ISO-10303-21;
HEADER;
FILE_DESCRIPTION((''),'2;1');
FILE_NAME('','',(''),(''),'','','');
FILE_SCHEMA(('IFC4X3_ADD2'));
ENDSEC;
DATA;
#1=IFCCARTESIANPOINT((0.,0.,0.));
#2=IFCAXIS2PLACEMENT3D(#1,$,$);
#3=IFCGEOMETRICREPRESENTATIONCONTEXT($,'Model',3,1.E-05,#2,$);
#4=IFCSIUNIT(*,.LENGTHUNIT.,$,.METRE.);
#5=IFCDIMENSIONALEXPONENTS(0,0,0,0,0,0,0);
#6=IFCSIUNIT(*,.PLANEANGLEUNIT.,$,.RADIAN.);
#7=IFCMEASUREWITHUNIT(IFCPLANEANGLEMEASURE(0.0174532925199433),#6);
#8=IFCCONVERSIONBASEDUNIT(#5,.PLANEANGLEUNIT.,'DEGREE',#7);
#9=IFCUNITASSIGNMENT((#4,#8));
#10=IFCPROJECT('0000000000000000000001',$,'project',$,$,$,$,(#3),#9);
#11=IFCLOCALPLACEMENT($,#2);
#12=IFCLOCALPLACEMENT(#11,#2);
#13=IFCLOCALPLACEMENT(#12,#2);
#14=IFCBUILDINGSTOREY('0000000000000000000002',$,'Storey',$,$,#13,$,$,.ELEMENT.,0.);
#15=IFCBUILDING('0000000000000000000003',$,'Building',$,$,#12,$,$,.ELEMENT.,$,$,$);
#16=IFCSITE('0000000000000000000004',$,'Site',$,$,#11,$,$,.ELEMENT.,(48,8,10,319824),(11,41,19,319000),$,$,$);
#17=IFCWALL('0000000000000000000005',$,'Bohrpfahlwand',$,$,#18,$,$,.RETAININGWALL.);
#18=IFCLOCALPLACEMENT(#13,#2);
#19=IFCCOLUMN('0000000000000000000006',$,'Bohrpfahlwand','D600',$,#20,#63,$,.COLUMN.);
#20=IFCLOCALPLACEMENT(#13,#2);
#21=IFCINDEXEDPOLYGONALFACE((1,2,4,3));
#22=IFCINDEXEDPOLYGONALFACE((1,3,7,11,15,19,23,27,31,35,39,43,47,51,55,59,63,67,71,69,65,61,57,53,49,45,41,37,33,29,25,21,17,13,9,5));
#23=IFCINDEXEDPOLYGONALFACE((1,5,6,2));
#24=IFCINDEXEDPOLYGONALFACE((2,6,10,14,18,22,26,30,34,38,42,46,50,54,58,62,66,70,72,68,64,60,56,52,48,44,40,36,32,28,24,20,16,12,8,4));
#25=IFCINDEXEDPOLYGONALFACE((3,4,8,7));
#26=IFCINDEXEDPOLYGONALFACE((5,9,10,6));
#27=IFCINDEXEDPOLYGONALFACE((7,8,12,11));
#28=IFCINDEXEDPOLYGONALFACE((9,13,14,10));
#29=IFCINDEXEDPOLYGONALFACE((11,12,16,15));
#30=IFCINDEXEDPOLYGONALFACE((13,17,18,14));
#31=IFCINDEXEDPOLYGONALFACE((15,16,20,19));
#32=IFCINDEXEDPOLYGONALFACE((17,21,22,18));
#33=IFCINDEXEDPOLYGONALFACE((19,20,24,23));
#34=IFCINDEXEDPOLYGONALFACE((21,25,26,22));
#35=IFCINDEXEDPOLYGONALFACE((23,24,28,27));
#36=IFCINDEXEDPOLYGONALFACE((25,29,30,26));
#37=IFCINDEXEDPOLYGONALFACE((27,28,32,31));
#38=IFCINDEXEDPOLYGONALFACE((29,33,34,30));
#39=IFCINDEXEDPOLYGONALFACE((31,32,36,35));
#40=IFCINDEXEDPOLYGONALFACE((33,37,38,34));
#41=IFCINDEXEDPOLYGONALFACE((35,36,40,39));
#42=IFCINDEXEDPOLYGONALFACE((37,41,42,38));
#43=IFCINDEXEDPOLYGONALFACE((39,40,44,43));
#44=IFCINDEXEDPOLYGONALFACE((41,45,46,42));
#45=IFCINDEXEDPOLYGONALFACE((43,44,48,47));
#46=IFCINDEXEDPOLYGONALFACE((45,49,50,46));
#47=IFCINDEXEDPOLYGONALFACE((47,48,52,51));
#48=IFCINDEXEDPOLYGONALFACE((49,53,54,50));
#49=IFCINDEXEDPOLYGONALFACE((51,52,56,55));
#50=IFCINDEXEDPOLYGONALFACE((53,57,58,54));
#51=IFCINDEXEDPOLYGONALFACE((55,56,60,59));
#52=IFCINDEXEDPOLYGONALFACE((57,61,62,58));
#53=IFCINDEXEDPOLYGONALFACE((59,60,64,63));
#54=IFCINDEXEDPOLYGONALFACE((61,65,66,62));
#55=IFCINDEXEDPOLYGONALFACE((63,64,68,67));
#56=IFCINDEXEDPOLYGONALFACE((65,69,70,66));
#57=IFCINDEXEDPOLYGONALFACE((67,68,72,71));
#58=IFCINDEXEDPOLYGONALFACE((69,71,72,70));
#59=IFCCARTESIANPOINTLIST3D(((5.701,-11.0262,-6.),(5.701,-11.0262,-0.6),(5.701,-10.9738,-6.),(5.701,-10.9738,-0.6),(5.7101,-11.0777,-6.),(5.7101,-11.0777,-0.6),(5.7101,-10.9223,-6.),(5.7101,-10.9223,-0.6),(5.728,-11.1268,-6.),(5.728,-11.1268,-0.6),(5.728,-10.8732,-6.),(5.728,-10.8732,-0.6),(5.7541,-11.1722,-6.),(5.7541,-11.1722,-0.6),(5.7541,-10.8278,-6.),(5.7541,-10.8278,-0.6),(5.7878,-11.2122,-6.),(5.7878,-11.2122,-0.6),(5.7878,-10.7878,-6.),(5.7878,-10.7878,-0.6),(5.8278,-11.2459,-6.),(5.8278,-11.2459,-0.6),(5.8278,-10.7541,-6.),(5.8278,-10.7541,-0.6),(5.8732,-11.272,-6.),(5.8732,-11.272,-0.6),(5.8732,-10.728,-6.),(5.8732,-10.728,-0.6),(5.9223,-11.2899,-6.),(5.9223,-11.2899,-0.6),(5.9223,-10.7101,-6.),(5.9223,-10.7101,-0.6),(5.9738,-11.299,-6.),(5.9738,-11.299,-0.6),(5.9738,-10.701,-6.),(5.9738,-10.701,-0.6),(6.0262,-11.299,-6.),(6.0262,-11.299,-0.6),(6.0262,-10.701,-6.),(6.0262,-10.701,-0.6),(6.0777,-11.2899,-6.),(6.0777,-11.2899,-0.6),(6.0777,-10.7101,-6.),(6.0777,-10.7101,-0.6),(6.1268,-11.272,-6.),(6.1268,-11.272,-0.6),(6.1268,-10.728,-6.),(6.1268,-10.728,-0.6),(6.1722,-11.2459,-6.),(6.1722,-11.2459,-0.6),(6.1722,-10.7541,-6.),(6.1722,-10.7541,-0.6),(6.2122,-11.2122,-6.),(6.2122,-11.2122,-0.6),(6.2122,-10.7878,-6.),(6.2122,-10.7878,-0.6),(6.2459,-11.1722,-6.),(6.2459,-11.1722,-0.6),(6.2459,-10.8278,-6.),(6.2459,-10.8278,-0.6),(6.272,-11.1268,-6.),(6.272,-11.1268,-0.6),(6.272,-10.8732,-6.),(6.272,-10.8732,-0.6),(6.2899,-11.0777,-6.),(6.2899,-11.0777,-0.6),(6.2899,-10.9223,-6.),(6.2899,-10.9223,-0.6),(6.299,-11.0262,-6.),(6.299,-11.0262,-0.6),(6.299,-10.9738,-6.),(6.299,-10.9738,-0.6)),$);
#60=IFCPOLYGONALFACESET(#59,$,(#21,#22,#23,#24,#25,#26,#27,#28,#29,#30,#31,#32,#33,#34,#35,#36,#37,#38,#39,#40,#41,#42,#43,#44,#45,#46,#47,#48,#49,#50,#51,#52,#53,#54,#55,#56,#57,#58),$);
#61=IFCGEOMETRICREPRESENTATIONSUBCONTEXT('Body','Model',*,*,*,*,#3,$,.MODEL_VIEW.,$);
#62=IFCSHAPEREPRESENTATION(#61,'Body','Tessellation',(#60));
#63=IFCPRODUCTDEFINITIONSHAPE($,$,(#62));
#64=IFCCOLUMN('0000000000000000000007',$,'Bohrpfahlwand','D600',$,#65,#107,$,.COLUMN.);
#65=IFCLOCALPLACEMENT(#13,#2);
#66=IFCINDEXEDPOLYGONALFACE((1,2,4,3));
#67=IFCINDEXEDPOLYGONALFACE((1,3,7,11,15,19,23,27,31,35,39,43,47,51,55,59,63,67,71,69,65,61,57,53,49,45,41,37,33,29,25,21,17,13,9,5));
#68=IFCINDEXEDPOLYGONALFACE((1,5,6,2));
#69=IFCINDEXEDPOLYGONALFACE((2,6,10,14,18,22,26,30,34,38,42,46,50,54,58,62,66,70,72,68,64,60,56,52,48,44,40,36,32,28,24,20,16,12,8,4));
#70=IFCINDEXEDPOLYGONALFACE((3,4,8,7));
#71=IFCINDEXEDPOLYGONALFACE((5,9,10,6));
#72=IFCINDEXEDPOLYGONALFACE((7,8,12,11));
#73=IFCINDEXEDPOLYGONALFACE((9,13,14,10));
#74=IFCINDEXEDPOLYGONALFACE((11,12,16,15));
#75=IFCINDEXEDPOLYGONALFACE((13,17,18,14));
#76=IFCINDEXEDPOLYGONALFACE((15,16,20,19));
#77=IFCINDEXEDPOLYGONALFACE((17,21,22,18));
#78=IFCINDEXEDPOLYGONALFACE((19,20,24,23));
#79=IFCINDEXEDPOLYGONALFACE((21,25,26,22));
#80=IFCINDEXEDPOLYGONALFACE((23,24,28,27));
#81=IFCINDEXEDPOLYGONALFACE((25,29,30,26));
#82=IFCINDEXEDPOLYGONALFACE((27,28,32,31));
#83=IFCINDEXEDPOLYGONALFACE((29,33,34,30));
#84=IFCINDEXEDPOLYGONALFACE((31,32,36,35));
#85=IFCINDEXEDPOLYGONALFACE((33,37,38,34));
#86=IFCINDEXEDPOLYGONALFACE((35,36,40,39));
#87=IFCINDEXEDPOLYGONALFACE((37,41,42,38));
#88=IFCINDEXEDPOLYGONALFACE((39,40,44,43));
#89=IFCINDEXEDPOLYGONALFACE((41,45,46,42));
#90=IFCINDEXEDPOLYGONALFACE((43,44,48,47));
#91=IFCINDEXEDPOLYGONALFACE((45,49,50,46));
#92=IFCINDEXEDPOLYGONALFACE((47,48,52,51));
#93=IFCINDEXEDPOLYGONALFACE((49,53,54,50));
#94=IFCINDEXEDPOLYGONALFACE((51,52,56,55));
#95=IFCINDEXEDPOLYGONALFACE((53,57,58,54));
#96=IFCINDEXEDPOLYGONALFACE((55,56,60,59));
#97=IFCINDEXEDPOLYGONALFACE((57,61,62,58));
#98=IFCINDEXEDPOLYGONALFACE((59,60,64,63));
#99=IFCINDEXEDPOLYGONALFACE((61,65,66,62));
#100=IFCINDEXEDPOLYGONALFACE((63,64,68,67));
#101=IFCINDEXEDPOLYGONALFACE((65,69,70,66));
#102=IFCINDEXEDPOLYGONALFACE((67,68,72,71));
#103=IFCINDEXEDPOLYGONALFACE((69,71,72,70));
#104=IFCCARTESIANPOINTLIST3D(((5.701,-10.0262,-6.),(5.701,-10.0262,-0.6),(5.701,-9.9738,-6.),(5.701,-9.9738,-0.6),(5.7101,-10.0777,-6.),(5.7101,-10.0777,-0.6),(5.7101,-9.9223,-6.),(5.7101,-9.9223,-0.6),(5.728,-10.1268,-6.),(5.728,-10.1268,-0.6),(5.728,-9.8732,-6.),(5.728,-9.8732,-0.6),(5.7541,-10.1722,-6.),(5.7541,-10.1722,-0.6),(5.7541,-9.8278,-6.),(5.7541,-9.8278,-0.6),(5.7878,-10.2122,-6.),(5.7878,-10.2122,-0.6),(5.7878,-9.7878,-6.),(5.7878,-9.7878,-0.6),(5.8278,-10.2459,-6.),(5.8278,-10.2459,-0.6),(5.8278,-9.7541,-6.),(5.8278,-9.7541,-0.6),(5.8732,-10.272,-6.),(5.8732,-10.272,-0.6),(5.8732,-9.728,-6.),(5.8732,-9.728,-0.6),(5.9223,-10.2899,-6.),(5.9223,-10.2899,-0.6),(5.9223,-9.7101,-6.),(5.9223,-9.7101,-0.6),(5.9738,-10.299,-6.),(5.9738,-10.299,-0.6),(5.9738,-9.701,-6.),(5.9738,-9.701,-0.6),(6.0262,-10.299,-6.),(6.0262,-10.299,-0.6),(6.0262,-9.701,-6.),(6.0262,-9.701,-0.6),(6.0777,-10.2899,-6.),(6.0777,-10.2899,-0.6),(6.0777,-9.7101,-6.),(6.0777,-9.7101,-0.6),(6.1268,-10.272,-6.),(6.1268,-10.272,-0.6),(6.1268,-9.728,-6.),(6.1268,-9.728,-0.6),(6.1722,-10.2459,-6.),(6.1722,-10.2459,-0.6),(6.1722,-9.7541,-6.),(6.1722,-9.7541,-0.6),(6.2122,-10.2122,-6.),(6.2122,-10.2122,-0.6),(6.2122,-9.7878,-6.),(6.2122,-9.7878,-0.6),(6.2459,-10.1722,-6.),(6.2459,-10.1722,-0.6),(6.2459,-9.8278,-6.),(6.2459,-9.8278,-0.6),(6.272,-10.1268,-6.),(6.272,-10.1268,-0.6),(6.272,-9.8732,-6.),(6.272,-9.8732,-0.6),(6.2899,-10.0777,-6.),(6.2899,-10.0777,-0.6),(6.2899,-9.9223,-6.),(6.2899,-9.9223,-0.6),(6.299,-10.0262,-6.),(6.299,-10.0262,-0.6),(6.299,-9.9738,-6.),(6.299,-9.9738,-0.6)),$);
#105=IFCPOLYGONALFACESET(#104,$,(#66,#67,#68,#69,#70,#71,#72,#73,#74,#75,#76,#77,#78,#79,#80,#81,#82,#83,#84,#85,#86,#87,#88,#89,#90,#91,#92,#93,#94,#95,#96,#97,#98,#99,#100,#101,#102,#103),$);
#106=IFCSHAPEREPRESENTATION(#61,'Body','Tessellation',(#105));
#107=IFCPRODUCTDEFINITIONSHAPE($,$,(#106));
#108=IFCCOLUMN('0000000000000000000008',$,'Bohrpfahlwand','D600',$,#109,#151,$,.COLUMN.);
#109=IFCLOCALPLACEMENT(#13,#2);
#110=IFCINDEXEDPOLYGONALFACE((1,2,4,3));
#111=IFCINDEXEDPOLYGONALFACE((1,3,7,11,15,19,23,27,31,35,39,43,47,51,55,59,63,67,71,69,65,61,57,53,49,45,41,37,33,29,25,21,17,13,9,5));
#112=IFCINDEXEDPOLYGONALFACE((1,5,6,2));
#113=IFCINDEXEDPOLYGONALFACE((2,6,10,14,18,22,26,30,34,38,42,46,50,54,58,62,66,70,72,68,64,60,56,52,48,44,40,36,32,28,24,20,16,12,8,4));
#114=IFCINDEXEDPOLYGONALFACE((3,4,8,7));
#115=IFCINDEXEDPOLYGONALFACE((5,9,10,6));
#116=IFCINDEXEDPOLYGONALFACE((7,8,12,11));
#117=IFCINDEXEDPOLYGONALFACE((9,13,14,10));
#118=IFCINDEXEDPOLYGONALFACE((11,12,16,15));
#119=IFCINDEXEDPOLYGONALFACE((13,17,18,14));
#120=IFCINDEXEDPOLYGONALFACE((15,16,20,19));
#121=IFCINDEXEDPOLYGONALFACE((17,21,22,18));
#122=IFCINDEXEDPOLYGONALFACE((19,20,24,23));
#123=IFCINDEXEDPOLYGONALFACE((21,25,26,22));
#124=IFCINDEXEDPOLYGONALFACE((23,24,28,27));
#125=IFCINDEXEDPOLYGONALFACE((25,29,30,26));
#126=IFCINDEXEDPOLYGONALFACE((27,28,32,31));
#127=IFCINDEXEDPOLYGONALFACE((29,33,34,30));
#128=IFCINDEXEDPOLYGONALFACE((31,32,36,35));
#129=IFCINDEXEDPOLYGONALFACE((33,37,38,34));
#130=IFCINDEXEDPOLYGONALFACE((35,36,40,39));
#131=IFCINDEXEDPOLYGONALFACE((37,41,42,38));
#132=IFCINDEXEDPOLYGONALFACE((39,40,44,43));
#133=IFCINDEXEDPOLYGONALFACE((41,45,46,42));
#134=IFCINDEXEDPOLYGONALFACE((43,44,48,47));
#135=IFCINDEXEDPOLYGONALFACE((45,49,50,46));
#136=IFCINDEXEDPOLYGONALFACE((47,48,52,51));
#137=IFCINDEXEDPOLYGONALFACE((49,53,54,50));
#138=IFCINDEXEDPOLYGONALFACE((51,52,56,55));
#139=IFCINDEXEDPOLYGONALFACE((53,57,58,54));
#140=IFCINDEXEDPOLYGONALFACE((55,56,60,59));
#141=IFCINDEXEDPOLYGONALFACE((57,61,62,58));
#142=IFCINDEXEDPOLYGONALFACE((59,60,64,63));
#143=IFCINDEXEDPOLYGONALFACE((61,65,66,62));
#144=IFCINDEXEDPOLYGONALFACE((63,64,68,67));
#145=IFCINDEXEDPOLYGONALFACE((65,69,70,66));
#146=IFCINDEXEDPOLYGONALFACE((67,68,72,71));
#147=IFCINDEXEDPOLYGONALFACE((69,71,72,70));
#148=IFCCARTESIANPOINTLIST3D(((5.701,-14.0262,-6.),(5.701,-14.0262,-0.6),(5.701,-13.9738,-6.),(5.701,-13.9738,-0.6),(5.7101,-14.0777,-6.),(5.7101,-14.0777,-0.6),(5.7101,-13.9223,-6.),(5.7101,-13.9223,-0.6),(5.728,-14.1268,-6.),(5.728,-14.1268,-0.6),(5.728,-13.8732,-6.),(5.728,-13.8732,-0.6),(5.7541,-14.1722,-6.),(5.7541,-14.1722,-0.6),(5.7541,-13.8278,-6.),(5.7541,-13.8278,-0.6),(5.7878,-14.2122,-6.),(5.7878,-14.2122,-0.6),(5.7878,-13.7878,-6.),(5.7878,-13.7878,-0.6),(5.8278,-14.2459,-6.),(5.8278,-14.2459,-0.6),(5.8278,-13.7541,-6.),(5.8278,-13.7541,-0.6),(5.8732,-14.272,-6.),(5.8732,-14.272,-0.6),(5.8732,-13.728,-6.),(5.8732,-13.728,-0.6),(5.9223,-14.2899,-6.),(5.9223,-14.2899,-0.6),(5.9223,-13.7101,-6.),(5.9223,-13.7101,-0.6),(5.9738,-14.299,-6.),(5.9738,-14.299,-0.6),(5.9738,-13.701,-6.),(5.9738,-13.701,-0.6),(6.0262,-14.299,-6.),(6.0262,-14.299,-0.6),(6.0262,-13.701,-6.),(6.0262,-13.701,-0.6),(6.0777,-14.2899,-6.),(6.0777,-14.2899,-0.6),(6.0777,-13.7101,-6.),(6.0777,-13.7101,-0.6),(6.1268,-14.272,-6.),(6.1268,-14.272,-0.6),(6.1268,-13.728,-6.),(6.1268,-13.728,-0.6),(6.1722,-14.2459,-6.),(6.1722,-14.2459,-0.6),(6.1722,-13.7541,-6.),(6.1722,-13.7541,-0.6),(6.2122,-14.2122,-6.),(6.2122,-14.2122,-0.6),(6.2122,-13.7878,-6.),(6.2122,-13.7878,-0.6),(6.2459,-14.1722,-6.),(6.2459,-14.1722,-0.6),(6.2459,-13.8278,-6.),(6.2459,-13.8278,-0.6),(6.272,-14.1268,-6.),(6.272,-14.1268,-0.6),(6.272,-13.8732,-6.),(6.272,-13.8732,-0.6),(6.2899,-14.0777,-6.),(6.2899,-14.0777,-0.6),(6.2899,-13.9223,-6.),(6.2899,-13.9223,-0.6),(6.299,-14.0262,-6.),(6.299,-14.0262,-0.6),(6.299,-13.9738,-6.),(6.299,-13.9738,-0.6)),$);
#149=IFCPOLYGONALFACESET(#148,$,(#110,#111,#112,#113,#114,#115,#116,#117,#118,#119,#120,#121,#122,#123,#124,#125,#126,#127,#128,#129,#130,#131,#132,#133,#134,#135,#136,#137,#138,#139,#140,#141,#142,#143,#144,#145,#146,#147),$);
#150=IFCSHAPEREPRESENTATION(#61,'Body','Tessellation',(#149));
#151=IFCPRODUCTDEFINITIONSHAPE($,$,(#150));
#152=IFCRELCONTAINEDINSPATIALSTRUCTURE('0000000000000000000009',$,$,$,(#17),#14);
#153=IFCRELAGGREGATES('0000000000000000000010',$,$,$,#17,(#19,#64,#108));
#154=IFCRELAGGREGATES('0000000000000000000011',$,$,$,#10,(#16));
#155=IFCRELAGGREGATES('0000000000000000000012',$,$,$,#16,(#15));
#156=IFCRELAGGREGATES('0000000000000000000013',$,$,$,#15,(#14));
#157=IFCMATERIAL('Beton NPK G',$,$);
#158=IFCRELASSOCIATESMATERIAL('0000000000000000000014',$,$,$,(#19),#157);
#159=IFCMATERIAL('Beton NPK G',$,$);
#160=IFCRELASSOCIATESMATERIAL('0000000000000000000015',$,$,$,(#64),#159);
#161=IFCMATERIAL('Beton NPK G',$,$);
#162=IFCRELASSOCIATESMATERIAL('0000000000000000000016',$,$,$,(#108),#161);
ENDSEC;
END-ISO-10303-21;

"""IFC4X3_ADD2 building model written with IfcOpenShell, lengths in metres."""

from ifc_helpers import new_model, entity, si_unit, converted_unit, frame, origin, origin_with_axes, place, context, subcontext, project, spatial, polyline, outline, extrude, material, element, aggregate, save


model = new_model("IFC4X3_ADD2")

# Units and contexts
model_context = context("Model", 3, precision=1e-05, world=origin())
body_context = subcontext(model_context, "Body", "Model", "MODEL_VIEW")
ifc_project = project(units=[si_unit("LENGTHUNIT", "METRE"), converted_unit("PLANEANGLEUNIT", "DEGREE", entity("IfcPlaneAngleMeasure", 0.0174532925199433), si_unit("PLANEANGLEUNIT", "RADIAN"), dimensions=[0, 0, 0, 0, 0, 0, 0])], contexts=[model_context])

# Site, building, storey
site_placement = place(None, origin())
site = spatial("IfcSite", under=ifc_project, at=site_placement, Name="Site", CompositionType="ELEMENT", RefLatitude=(48, 8, 10, 319824), RefLongitude=(11, 41, 19, 319000))
building_placement = place(site_placement, origin())
building = spatial("IfcBuilding", under=site, at=building_placement, Name="Building", CompositionType="ELEMENT")
storey_placement = place(building_placement, origin())
storey = spatial("IfcBuildingStorey", under=building, at=storey_placement, Name="Storey", CompositionType="ELEMENT", Elevation=0.0)

# Wall, columns
wall_1_placement = place(storey_placement, origin())
wall_1 = element("IfcWall", 1, at=wall_1_placement, inside=storey, Name="Bohrpfahlwand", PredefinedType="RETAININGWALL")
ifc_material_1 = material(Name="Beton NPK G")
column_1_placement = place(wall_1_placement, frame((5.701, -11.299, -6.0)))
column_1 = element("IfcColumn", 2, at=column_1_placement, material=ifc_material_1, Name="Bohrpfahlwand", Description="D600", PredefinedType="COLUMN", context=body_context, shape_type="SweptSolid", body=[
    extrude(outline(polyline([(0.3252, 0.598), (0.2728, 0.598), (0.2213, 0.5889), (0.1722, 0.571), (0.1268, 0.5449), (0.0868, 0.5112), (0.0531, 0.4712), (0.027, 0.4258), (0.0091, 0.3767), (0.0, 0.3252), (0.0, 0.2728), (0.0091, 0.2213), (0.027, 0.1722), (0.0531, 0.1268), (0.0868, 0.0868), (0.1268, 0.0531), (0.1722, 0.027), (0.2213, 0.0091), (0.2728, 0.0), (0.3252, 0.0), (0.3767, 0.0091), (0.4258, 0.027), (0.4712, 0.0531), (0.5112, 0.0868), (0.5449, 0.1268), (0.571, 0.1722), (0.5889, 0.2213), (0.598, 0.2728), (0.598, 0.3252), (0.5889, 0.3767), (0.571, 0.4258), (0.5449, 0.4712), (0.5112, 0.5112), (0.4712, 0.5449), (0.4258, 0.571), (0.3767, 0.5889), (0.3252, 0.598)])), origin_with_axes(), (0.0, 0.0, 1.0), 5.4),
])
ifc_material_2 = material(Name="Beton NPK G")
column_2_placement = place(wall_1_placement, frame((5.701, -10.299, -6.0)))
column_2 = element("IfcColumn", 3, at=column_2_placement, material=ifc_material_2, Name="Bohrpfahlwand", Description="D600", PredefinedType="COLUMN", context=body_context, shape_type="SweptSolid", body=[
    extrude(outline(polyline([(0.3252, 0.598), (0.2728, 0.598), (0.2213, 0.5889), (0.1722, 0.571), (0.1268, 0.5449), (0.0868, 0.5112), (0.0531, 0.4712), (0.027, 0.4258), (0.0091, 0.3767), (0.0, 0.3252), (0.0, 0.2728), (0.0091, 0.2213), (0.027, 0.1722), (0.0531, 0.1268), (0.0868, 0.0868), (0.1268, 0.0531), (0.1722, 0.027), (0.2213, 0.0091), (0.2728, 0.0), (0.3252, 0.0), (0.3767, 0.0091), (0.4258, 0.027), (0.4712, 0.0531), (0.5112, 0.0868), (0.5449, 0.1268), (0.571, 0.1722), (0.5889, 0.2213), (0.598, 0.2728), (0.598, 0.3252), (0.5889, 0.3767), (0.571, 0.4258), (0.5449, 0.4712), (0.5112, 0.5112), (0.4712, 0.5449), (0.4258, 0.571), (0.3767, 0.5889), (0.3252, 0.598)])), origin_with_axes(), (0.0, 0.0, 1.0), 5.4),
])
ifc_material_3 = material(Name="Beton NPK G")
column_3_placement = place(wall_1_placement, frame((5.701, -14.299, -6.0)))
column_3 = element("IfcColumn", 4, at=column_3_placement, material=ifc_material_3, Name="Bohrpfahlwand", Description="D600", PredefinedType="COLUMN", context=body_context, shape_type="SweptSolid", body=[
    extrude(outline(polyline([(0.3252, 0.598), (0.2728, 0.598), (0.2213, 0.5889), (0.1722, 0.571), (0.1268, 0.5449), (0.0868, 0.5112), (0.0531, 0.4712), (0.027, 0.4258), (0.0091, 0.3767), (0.0, 0.3252), (0.0, 0.2728), (0.0091, 0.2213), (0.027, 0.1722), (0.0531, 0.1268), (0.0868, 0.0868), (0.1268, 0.0531), (0.1722, 0.027), (0.2213, 0.0091), (0.2728, 0.0), (0.3252, 0.0), (0.3767, 0.0091), (0.4258, 0.027), (0.4712, 0.0531), (0.5112, 0.0868), (0.5449, 0.1268), (0.571, 0.1722), (0.5889, 0.2213), (0.598, 0.2728), (0.598, 0.3252), (0.5889, 0.3767), (0.571, 0.4258), (0.5449, 0.4712), (0.5112, 0.5112), (0.4712, 0.5449), (0.4258, 0.571), (0.3767, 0.5889), (0.3252, 0.598)])), origin_with_axes(), (0.0, 0.0, 1.0), 5.4),
])
aggregate(wall_1, [column_1, column_2, column_3])

save(model, "model.ifc")
